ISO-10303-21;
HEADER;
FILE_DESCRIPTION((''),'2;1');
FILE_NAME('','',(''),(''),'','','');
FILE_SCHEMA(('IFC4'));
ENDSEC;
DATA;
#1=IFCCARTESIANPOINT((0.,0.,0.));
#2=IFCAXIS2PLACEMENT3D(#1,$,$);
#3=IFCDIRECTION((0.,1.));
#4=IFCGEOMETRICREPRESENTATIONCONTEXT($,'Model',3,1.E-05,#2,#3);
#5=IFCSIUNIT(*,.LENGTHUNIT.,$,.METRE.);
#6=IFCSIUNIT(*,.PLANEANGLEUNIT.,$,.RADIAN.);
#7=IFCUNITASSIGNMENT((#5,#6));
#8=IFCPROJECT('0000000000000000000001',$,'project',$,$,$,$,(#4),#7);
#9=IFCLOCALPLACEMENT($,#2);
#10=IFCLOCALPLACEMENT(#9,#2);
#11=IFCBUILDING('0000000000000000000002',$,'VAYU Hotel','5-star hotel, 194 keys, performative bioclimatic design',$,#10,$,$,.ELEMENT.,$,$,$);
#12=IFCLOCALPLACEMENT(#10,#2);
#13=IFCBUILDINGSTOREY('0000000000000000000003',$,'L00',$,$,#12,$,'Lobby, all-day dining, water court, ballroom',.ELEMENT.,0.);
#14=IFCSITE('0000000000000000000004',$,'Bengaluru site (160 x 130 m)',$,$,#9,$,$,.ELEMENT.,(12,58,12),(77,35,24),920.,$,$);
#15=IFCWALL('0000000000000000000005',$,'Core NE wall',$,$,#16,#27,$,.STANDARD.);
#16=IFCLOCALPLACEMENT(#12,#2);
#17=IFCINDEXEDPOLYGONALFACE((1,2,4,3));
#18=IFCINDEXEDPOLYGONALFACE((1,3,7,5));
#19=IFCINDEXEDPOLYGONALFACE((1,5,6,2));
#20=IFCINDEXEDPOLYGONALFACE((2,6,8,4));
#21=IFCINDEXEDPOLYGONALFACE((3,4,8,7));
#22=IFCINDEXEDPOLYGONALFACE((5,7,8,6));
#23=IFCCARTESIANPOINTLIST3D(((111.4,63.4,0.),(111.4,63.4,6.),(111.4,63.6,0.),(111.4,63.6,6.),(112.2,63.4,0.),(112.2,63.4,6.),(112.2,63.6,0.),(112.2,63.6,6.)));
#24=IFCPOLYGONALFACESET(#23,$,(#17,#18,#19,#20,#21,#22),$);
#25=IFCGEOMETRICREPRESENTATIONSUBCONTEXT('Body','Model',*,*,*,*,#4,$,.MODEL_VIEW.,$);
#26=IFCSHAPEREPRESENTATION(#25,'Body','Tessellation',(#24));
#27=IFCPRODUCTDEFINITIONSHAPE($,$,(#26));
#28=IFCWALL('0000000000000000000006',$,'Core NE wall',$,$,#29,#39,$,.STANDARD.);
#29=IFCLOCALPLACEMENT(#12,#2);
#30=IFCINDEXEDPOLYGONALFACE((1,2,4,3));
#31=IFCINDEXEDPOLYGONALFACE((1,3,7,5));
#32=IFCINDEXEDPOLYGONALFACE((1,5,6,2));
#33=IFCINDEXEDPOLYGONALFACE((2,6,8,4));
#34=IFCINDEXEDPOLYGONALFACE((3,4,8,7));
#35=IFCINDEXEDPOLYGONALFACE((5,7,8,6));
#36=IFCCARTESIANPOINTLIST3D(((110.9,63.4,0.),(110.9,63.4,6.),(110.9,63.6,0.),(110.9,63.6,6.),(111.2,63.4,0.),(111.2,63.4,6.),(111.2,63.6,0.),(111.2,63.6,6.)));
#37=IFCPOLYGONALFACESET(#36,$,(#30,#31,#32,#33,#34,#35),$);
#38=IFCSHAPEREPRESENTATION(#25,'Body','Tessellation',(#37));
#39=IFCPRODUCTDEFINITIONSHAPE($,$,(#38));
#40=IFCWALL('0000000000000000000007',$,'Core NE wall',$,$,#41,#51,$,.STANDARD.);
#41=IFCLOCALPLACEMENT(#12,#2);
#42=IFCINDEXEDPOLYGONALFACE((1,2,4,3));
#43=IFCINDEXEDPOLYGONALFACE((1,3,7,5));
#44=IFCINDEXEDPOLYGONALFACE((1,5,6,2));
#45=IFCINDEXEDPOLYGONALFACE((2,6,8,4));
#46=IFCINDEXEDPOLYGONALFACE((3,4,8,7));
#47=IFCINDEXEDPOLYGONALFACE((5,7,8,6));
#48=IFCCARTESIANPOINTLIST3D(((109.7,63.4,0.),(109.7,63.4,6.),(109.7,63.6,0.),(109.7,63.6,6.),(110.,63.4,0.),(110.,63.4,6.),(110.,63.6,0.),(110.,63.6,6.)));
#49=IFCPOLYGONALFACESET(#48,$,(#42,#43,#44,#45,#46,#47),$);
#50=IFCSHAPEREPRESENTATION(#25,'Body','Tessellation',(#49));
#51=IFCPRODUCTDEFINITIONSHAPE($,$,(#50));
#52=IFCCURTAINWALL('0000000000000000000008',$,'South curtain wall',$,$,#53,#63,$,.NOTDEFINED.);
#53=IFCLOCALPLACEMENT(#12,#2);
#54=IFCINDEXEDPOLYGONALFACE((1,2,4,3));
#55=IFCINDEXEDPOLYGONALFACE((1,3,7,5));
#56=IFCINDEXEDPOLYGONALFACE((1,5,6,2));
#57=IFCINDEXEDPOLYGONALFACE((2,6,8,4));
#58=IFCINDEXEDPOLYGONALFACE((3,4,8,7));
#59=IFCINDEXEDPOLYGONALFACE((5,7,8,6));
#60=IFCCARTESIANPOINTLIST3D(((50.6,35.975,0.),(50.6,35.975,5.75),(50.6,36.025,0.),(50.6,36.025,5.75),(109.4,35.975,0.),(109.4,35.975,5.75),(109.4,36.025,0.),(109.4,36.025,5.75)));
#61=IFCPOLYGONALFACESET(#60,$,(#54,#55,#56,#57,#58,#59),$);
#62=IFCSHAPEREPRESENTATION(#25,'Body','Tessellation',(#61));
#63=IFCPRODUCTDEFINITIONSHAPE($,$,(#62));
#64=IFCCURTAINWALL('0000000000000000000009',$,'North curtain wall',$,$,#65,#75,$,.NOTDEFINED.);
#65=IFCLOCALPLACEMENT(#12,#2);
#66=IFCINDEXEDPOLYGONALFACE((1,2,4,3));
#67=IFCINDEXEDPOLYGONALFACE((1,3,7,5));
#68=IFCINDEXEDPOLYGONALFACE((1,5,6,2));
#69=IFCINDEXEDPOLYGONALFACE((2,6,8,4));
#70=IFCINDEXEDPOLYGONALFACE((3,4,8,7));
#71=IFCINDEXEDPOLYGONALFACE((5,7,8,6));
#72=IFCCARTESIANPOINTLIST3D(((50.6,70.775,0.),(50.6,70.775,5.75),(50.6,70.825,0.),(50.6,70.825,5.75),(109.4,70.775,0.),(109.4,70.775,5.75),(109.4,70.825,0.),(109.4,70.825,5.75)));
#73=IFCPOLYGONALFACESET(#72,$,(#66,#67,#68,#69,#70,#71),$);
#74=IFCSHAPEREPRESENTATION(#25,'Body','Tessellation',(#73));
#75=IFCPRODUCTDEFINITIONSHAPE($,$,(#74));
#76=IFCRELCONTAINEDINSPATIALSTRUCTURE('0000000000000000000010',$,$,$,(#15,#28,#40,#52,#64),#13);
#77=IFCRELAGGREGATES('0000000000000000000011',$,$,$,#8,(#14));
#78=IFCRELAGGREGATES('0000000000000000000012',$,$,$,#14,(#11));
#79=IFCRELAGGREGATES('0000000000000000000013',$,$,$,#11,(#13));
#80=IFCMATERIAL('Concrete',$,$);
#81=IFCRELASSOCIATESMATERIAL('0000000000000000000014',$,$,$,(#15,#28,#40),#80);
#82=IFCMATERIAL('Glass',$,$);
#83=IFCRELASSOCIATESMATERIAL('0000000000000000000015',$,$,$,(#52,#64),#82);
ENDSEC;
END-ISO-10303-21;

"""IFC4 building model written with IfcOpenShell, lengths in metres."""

from ifc_helpers import new_model, si_unit, direction, origin, place, context, subcontext, project, spatial, polyline, outline, extrude, material, element, save


model = new_model("IFC4")

# Units and contexts
model_context = context("Model", 3, precision=1e-05, world=origin(), true_north=direction((0.0, 1.0)))
body_context = subcontext(model_context, "Body", "Model", "MODEL_VIEW")
ifc_project = project(units=[si_unit("LENGTHUNIT", "METRE"), si_unit("PLANEANGLEUNIT", "RADIAN")], contexts=[model_context])

# Site, building, storey
site_placement = place(None, origin())
site = spatial("IfcSite", under=ifc_project, at=site_placement, Name="Bengaluru site (160 x 130 m)", CompositionType="ELEMENT", RefLatitude=(12, 58, 12), RefLongitude=(77, 35, 24), RefElevation=920.0)
building_placement = place(site_placement, origin())
building = spatial("IfcBuilding", under=site, at=building_placement, Name="VAYU Hotel", Description="5-star hotel, 194 keys, performative bioclimatic design", CompositionType="ELEMENT")
storey_placement = place(building_placement, origin())
storey = spatial("IfcBuildingStorey", under=building, at=storey_placement, Name="L00", LongName="Lobby, all-day dining, water court, ballroom", CompositionType="ELEMENT", Elevation=0.0)

# Shared definitions
ifc_material_1 = material(Name="Concrete")

# Walls
wall_1_placement = place(storey_placement, origin())
element("IfcWall", 1, at=wall_1_placement, inside=storey, material=ifc_material_1, Name="Core NE wall", PredefinedType="STANDARD", context=body_context, shape_type="SweptSolid", body=[
    extrude(outline(polyline([(111.4, 63.6), (112.2, 63.6), (112.2, 63.4), (111.4, 63.4), (111.4, 63.6)])), origin(), (0.0, 0.0, 1.0), 6.0),
])
wall_2_placement = place(storey_placement, origin())
element("IfcWall", 2, at=wall_2_placement, inside=storey, material=ifc_material_1, Name="Core NE wall", PredefinedType="STANDARD", context=body_context, shape_type="SweptSolid", body=[
    extrude(outline(polyline([(110.9, 63.6), (111.2, 63.6), (111.2, 63.4), (110.9, 63.4), (110.9, 63.6)])), origin(), (0.0, 0.0, 1.0), 6.0),
])
wall_3_placement = place(storey_placement, origin())
element("IfcWall", 3, at=wall_3_placement, inside=storey, material=ifc_material_1, Name="Core NE wall", PredefinedType="STANDARD", context=body_context, shape_type="SweptSolid", body=[
    extrude(outline(polyline([(109.7, 63.6), (110.0, 63.6), (110.0, 63.4), (109.7, 63.4), (109.7, 63.6)])), origin(), (0.0, 0.0, 1.0), 6.0),
])

# Curtain walls
ifc_material_2 = material(Name="Glass")
curtain_wall_1_placement = place(storey_placement, origin())
element("IfcCurtainWall", 4, at=curtain_wall_1_placement, inside=storey, material=ifc_material_2, Name="South curtain wall", PredefinedType="NOTDEFINED", context=body_context, shape_type="SweptSolid", body=[
    extrude(outline(polyline([(50.6, 36.025), (109.4, 36.025), (109.4, 35.975), (50.6, 35.975), (50.6, 36.025)])), origin(), (0.0, 0.0, 1.0), 5.75),
])
curtain_wall_2_placement = place(storey_placement, origin())
element("IfcCurtainWall", 5, at=curtain_wall_2_placement, inside=storey, material=ifc_material_2, Name="North curtain wall", PredefinedType="NOTDEFINED", context=body_context, shape_type="SweptSolid", body=[
    extrude(outline(polyline([(50.6, 70.825), (109.4, 70.825), (109.4, 70.775), (50.6, 70.775), (50.6, 70.825)])), origin(), (0.0, 0.0, 1.0), 5.75),
])

save(model, "model.ifc")
